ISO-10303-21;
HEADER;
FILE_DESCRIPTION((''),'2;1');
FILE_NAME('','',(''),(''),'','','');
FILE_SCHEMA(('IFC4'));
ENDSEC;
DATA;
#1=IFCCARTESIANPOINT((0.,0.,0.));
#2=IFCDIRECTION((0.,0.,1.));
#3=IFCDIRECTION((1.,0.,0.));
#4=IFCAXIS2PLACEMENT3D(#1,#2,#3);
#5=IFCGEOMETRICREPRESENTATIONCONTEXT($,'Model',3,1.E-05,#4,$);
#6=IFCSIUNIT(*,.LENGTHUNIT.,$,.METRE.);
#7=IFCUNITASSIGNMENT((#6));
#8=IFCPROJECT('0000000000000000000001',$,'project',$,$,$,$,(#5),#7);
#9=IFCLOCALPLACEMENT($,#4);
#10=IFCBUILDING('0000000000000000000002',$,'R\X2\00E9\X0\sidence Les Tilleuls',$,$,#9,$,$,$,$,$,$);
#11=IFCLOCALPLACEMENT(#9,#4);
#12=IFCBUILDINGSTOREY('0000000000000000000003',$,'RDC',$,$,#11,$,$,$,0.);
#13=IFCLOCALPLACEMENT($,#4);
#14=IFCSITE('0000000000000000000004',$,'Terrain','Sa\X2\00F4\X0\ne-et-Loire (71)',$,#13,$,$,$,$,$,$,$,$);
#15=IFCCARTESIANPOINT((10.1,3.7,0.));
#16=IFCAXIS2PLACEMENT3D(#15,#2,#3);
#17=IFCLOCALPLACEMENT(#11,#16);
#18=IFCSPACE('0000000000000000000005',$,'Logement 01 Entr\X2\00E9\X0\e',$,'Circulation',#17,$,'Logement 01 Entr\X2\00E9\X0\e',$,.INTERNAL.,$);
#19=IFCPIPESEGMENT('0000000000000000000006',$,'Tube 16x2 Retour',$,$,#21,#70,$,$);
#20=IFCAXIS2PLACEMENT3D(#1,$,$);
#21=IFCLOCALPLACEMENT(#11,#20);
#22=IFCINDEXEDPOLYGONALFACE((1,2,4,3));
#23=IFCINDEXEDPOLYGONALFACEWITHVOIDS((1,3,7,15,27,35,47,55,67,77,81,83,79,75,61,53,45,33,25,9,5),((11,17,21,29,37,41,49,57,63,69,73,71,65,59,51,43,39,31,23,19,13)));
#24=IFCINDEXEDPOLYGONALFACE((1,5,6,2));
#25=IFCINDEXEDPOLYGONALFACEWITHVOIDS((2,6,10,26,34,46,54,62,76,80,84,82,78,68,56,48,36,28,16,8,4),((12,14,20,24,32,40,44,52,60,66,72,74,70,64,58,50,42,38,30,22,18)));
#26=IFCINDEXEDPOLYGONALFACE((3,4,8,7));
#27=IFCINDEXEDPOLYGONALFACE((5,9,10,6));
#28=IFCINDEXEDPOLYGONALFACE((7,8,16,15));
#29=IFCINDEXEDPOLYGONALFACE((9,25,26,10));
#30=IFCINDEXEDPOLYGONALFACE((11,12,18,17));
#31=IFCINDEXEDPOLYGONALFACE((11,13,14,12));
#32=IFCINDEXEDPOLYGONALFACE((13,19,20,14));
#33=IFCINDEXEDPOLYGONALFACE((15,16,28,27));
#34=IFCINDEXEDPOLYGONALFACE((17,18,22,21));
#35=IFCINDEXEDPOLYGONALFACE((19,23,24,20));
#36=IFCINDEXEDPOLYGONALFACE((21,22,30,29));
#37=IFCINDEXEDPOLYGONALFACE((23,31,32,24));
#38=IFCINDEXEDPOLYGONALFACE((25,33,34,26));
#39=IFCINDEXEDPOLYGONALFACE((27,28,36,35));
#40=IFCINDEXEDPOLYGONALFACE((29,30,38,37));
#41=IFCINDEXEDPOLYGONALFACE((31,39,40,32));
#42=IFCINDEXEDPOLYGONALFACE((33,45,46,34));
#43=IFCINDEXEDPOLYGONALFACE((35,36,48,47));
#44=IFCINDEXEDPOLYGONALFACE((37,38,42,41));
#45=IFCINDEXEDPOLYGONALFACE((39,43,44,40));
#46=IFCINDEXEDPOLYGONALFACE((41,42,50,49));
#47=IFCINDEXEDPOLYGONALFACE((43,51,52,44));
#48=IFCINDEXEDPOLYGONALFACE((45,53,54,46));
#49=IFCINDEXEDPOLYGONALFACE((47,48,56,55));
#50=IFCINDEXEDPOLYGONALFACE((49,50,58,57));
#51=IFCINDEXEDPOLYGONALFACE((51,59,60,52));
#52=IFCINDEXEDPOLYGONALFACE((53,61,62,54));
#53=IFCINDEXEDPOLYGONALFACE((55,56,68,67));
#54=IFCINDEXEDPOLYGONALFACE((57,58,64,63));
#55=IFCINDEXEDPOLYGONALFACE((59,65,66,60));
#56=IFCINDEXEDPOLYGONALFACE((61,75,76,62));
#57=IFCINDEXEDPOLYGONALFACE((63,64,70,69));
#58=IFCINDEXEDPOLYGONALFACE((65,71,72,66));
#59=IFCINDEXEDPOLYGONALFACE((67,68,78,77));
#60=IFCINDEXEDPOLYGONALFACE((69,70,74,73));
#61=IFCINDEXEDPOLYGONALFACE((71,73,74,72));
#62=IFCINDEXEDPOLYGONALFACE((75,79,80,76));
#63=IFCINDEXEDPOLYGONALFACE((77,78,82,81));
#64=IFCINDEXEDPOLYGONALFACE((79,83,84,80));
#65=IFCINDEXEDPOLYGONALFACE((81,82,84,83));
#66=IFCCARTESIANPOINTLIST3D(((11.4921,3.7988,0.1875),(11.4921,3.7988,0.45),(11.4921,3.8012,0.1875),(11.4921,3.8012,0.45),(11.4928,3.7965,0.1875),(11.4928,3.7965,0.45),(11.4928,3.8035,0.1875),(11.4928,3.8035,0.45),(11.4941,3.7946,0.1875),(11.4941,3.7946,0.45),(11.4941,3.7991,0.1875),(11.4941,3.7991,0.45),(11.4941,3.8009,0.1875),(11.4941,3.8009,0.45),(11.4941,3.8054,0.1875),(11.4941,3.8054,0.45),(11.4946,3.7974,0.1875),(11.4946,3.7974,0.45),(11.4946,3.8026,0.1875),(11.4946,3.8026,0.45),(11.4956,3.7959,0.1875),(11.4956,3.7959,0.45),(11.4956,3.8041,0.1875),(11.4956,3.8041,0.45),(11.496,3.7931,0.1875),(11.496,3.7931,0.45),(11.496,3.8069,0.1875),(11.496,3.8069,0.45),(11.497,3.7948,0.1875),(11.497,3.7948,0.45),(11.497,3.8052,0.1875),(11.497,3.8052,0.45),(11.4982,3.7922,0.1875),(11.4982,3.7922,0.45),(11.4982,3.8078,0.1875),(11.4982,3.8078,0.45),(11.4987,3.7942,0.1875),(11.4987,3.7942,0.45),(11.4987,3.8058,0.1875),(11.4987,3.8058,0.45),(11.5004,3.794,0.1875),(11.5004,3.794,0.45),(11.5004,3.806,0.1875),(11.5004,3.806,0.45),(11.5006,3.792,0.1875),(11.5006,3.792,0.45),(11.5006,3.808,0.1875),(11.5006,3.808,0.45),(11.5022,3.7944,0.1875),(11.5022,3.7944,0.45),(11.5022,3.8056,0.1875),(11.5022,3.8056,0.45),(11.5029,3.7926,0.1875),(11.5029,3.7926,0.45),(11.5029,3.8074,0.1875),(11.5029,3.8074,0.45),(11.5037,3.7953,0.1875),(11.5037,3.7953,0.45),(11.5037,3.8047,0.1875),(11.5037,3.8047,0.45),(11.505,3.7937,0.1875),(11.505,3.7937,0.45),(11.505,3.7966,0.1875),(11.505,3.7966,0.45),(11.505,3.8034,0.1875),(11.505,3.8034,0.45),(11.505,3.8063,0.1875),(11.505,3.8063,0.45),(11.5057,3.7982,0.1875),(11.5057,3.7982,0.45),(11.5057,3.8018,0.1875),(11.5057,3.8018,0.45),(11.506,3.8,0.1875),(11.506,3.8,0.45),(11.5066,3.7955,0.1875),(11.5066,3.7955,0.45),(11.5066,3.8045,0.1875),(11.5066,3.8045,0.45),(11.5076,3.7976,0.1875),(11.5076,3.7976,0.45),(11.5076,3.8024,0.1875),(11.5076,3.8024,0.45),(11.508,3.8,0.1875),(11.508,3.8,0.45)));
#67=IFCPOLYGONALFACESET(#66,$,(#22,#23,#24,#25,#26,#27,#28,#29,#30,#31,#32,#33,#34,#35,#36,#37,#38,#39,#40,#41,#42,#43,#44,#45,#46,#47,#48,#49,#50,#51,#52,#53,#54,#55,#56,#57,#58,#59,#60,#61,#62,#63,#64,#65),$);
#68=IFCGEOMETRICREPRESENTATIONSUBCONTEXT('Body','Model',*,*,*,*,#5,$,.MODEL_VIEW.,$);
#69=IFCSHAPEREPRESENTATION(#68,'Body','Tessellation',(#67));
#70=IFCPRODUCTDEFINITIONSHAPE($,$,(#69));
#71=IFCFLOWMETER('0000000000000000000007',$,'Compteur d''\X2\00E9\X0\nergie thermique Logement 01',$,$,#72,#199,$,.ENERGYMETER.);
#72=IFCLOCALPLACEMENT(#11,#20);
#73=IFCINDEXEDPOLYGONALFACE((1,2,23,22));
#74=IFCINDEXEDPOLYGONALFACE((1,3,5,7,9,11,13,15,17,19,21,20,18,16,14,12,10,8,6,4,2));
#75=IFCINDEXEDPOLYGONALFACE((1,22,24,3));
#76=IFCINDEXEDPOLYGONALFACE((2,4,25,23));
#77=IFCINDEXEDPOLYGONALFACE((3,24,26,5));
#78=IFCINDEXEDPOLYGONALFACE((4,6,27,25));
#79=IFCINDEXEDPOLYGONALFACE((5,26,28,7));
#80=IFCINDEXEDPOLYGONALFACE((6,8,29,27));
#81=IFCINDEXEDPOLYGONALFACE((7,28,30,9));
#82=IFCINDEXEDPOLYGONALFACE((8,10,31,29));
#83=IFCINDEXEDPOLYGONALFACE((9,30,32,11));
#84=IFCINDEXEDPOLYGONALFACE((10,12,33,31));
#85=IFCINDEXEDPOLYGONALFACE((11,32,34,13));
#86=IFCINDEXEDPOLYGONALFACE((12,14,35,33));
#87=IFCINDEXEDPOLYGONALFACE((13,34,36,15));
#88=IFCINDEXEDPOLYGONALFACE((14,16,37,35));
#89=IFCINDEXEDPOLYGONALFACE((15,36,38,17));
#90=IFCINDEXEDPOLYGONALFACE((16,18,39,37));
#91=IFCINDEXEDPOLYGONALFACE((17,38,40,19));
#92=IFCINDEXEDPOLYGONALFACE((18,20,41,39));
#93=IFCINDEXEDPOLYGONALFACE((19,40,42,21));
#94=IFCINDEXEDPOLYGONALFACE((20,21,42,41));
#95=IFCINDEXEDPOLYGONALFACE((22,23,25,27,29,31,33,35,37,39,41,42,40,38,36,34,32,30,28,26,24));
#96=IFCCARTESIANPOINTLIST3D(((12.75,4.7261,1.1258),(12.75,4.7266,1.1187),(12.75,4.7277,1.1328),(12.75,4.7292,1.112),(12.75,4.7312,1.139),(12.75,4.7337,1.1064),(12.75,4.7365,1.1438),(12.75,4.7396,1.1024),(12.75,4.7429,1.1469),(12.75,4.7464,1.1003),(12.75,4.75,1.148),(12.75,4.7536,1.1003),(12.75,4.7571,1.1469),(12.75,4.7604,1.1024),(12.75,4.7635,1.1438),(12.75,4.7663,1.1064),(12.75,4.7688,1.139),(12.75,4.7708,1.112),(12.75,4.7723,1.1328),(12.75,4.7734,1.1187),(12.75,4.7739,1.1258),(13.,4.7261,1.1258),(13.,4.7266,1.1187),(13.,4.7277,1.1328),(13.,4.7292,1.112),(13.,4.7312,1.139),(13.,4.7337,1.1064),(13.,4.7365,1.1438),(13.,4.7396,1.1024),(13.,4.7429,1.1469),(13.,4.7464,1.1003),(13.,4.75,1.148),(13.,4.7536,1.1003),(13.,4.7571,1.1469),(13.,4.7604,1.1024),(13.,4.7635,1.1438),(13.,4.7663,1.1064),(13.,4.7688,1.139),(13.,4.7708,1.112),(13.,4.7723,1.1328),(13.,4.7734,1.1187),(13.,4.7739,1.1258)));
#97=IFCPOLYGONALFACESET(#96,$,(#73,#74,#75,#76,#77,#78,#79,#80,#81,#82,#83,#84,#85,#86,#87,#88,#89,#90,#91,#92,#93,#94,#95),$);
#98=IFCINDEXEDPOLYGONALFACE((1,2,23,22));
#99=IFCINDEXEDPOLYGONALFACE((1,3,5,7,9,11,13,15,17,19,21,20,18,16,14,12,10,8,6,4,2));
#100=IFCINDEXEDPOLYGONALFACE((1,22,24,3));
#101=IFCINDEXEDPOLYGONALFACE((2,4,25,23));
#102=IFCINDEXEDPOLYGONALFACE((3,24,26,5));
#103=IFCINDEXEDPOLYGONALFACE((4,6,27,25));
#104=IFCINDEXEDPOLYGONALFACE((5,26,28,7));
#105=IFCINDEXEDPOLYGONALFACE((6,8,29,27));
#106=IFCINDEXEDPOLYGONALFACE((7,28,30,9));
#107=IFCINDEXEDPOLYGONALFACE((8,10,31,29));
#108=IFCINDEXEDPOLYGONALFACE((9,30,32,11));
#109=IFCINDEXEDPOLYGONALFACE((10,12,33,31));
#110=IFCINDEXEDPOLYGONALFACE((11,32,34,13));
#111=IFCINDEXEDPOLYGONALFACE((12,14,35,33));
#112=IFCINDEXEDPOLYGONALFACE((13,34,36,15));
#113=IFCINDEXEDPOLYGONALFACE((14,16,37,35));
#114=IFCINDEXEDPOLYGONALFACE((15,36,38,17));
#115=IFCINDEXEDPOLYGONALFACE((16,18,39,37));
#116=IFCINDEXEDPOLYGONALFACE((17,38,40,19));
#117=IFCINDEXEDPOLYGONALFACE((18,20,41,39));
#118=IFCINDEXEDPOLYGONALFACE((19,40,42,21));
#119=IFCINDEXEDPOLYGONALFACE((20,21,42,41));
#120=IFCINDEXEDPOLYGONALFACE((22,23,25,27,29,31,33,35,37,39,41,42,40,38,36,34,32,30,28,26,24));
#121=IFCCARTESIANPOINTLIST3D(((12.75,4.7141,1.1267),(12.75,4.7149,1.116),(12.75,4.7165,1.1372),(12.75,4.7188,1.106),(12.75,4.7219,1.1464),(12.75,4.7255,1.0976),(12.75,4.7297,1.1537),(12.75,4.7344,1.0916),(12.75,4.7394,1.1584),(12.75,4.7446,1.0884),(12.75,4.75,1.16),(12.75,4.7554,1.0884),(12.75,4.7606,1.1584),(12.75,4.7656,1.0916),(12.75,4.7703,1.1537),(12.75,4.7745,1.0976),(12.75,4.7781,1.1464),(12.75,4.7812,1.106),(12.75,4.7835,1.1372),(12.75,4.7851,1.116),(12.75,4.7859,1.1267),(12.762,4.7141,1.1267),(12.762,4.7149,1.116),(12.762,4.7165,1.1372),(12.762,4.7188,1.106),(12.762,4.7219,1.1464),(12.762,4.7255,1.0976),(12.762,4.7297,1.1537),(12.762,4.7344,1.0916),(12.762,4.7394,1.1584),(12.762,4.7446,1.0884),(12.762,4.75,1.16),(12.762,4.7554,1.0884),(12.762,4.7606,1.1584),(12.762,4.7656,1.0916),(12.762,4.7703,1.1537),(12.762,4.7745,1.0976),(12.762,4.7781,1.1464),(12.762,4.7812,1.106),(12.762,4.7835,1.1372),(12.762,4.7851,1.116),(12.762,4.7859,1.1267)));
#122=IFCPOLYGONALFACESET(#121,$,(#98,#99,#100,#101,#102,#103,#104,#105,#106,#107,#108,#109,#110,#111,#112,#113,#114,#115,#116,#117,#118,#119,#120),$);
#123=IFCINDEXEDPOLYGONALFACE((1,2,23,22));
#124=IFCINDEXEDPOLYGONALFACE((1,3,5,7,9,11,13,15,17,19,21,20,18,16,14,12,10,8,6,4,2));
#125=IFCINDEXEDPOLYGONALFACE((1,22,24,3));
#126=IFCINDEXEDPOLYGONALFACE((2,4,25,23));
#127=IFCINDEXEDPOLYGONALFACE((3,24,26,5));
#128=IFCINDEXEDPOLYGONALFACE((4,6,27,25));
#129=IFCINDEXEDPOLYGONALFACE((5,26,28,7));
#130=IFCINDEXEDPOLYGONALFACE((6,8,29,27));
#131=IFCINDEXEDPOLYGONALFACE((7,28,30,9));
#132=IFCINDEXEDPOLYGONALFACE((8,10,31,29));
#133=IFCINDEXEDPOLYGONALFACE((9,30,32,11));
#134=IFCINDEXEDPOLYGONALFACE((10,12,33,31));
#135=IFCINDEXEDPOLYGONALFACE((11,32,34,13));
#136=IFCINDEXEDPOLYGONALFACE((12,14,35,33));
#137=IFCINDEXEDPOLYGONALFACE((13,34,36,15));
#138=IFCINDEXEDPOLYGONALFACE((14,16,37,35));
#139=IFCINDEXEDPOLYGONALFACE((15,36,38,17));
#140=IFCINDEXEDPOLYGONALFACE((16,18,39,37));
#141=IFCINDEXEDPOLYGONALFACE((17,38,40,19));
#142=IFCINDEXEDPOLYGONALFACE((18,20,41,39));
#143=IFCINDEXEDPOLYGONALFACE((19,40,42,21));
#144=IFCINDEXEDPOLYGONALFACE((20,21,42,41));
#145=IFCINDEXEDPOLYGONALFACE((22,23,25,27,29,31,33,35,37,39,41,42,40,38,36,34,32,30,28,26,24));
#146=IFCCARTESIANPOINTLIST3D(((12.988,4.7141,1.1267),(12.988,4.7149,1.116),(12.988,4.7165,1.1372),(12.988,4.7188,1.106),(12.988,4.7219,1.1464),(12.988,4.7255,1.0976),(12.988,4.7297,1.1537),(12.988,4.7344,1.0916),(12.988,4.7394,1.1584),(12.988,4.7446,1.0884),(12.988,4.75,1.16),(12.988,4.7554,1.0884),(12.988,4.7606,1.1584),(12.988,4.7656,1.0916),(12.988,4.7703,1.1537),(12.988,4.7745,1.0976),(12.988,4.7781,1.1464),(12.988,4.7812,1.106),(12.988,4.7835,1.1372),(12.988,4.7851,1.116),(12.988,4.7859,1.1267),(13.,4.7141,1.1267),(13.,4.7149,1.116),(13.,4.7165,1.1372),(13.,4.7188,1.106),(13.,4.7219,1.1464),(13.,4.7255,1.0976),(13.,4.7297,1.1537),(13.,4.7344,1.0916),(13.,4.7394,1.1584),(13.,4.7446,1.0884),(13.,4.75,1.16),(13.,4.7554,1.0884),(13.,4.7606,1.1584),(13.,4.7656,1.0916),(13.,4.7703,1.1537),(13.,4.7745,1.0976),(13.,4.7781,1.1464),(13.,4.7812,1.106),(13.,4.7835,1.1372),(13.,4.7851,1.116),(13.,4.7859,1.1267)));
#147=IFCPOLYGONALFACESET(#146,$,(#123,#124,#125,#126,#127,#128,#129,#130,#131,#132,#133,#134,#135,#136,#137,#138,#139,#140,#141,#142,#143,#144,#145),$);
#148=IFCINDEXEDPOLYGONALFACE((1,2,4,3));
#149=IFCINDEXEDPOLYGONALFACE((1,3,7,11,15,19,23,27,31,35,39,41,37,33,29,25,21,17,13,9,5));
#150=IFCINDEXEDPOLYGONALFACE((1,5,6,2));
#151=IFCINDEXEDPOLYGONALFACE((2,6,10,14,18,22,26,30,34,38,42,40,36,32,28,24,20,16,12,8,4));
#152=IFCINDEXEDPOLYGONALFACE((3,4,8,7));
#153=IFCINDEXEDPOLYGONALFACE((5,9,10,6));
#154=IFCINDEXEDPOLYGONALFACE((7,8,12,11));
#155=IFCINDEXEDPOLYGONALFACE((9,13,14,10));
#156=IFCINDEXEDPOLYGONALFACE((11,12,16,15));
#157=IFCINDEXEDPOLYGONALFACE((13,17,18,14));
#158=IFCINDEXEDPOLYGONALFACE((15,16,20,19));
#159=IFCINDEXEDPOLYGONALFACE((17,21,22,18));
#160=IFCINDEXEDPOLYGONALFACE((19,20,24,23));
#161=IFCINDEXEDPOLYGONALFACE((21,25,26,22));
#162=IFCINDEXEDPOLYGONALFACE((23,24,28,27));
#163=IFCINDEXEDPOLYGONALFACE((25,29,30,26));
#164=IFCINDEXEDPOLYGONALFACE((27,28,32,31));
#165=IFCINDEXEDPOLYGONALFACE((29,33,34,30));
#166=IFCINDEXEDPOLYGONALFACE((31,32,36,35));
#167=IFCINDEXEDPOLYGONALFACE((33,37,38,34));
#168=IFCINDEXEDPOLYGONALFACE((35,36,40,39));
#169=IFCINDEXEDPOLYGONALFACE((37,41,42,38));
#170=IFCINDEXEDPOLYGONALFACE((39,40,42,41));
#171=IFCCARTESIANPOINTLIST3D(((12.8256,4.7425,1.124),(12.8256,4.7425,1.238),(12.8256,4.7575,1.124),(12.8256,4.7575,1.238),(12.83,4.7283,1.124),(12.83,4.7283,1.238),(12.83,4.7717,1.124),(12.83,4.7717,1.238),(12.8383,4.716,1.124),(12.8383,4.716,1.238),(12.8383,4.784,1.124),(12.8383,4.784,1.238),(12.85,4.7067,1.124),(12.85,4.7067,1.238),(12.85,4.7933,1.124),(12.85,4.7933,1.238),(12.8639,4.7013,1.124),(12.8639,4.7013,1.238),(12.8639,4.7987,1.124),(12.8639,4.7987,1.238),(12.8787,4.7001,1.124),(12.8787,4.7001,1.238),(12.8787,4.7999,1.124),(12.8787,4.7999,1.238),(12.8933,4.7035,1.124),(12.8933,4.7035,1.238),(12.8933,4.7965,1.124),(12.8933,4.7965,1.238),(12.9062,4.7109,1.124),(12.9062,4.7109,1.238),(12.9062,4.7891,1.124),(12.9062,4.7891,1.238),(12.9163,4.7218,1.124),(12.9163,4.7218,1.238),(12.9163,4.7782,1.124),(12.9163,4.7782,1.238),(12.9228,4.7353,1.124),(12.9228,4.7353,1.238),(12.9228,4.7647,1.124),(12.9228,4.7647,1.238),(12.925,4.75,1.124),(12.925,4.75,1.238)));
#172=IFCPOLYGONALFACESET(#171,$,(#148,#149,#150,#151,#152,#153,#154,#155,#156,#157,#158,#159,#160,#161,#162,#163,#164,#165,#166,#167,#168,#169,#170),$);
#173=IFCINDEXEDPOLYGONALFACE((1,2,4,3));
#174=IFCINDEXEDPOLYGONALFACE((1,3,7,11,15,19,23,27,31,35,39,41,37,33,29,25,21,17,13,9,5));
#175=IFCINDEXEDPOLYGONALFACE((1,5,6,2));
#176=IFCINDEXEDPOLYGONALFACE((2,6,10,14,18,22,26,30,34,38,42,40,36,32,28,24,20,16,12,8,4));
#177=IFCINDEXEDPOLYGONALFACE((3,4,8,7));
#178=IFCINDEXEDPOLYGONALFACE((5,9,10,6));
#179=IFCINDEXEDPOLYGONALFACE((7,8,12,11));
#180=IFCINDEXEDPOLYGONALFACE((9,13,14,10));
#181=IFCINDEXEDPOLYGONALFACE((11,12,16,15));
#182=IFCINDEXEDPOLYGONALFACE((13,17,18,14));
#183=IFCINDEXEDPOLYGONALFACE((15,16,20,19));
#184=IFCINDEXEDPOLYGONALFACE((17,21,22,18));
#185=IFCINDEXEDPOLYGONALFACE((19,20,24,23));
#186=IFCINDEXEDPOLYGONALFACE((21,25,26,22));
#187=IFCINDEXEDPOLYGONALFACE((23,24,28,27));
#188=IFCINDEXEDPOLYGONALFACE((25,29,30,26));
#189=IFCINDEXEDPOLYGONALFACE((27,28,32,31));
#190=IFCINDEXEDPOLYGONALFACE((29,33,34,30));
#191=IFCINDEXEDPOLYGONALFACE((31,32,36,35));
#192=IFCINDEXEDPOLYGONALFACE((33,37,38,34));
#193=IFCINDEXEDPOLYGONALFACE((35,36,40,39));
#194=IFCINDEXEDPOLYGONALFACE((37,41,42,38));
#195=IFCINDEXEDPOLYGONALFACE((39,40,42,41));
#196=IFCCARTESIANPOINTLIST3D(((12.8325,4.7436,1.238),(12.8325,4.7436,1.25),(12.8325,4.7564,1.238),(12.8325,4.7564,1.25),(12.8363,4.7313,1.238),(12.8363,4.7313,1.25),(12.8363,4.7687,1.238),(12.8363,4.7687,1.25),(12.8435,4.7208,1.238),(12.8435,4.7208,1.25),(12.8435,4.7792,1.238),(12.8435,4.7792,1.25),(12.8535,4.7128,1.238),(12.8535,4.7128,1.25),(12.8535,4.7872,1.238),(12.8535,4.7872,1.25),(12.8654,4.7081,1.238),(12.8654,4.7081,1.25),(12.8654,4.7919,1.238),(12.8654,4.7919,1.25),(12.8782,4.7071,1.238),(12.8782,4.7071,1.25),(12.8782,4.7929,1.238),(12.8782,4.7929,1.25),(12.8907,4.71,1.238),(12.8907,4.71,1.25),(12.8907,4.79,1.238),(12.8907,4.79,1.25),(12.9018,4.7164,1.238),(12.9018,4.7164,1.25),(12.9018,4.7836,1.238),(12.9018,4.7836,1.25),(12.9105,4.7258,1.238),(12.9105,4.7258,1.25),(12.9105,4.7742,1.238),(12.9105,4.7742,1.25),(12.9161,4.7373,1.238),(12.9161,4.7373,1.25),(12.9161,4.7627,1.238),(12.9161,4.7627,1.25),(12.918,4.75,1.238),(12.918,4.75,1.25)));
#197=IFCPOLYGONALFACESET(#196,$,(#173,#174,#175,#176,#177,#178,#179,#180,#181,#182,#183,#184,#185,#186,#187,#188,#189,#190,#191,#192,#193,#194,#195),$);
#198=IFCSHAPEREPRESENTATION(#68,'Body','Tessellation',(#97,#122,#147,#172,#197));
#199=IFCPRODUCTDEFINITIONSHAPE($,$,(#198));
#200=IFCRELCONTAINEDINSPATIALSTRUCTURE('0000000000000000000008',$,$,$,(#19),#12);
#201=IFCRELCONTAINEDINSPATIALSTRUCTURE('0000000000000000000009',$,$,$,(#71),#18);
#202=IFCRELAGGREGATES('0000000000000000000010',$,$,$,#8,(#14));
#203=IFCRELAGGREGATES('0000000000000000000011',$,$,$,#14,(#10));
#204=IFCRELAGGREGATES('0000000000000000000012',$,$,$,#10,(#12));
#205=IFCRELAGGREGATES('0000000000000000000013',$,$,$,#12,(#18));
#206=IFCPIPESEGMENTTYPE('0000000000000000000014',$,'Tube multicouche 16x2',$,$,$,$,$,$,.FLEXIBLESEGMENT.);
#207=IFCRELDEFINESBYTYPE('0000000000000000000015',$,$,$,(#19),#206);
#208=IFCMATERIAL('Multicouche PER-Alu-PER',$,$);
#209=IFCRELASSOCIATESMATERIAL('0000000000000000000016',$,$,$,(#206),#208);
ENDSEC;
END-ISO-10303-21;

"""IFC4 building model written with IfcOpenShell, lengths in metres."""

from ifc_helpers import new_model, si_unit, frame, origin_with_axes, place, context, subcontext, project, spatial, circle, hollow_circle, extrude, material, type_object, element, save


model = new_model("IFC4")

# Units and contexts
model_context = context("Model", 3, precision=1e-05, world=origin_with_axes())
body_context = subcontext(model_context, "Body", "Model", "MODEL_VIEW")
ifc_project = project(units=[si_unit("LENGTHUNIT", "METRE")], contexts=[model_context])

# Site, building, storey
site_placement = place(None, origin_with_axes())
site = spatial("IfcSite", under=ifc_project, at=site_placement, Name="Terrain", Description="Saône-et-Loire (71)")
building_placement = place(None, origin_with_axes())
building = spatial("IfcBuilding", under=site, at=building_placement, Name="Résidence Les Tilleuls")
storey_placement = place(building_placement, origin_with_axes())
storey = spatial("IfcBuildingStorey", under=building, at=storey_placement, Name="RDC", Elevation=0.0)

# Pipe segment
ifc_material = material(Name="Multicouche PER-Alu-PER")
pipe_segment_type_1 = type_object("IfcPipeSegmentType", Name="Tube multicouche 16x2", PredefinedType="FLEXIBLESEGMENT", material=ifc_material)
pipe_segment_1_placement = place(storey_placement, frame((11.5, 3.8, 0.1875), z_axis=(0.0, 0.0, 1.0), x_axis=(1.0, 0.0, 0.0)))
element("IfcPipeSegment", 1, at=pipe_segment_1_placement, inside=storey, type_object=pipe_segment_type_1, Name="Tube 16x2 Retour", context=body_context, shape_type="SweptSolid", body=[
    extrude(hollow_circle(Radius=0.008, WallThickness=0.002), origin_with_axes(), (0.0, 0.0, 1.0), 0.2625),
])

# Shared definitions
space_1_placement = place(storey_placement, frame((10.1, 3.7, 0.0), z_axis=(0.0, 0.0, 1.0), x_axis=(1.0, 0.0, 0.0)))
space_1 = spatial("IfcSpace", under=storey, at=space_1_placement, Name="Logement 01 Entrée", ObjectType="Circulation", LongName="Logement 01 Entrée", PredefinedType="INTERNAL")

# Flow meter
flow_meter_placement = place(space_1_placement, frame((2.65, 1.0, 1.1), z_axis=(0.0, 0.0, 1.0), x_axis=(1.0, 0.0, 0.0)))
element("IfcFlowMeter", 2, at=flow_meter_placement, inside=space_1, Name="Compteur d'énergie thermique Logement 01", PredefinedType="ENERGYMETER", context=body_context, shape_type="SweptSolid", body=[
    extrude(circle(Radius=0.024), frame((0.0, 0.05, 0.024), z_axis=(1.0, 0.0, 0.0), x_axis=(0.0, 0.0, 1.0)), (0.0, 0.0, 1.0), 0.25),
    extrude(circle(Radius=0.036), frame((0.0, 0.05, 0.024), z_axis=(1.0, 0.0, 0.0), x_axis=(0.0, 0.0, 1.0)), (0.0, 0.0, 1.0), 0.012),
    extrude(circle(Radius=0.036), frame((0.238, 0.05, 0.024), z_axis=(1.0, 0.0, 0.0), x_axis=(0.0, 0.0, 1.0)), (0.0, 0.0, 1.0), 0.012),
    extrude(circle(Radius=0.05), frame((0.125, 0.05, 0.024), z_axis=(0.0, 0.0, 1.0), x_axis=(1.0, 0.0, 0.0)), (0.0, 0.0, 1.0), 0.114),
    extrude(circle(Radius=0.043), frame((0.125, 0.05, 0.138), z_axis=(0.0, 0.0, 1.0), x_axis=(1.0, 0.0, 0.0)), (0.0, 0.0, 1.0), 0.012),
])

save(model, "model.ifc")
